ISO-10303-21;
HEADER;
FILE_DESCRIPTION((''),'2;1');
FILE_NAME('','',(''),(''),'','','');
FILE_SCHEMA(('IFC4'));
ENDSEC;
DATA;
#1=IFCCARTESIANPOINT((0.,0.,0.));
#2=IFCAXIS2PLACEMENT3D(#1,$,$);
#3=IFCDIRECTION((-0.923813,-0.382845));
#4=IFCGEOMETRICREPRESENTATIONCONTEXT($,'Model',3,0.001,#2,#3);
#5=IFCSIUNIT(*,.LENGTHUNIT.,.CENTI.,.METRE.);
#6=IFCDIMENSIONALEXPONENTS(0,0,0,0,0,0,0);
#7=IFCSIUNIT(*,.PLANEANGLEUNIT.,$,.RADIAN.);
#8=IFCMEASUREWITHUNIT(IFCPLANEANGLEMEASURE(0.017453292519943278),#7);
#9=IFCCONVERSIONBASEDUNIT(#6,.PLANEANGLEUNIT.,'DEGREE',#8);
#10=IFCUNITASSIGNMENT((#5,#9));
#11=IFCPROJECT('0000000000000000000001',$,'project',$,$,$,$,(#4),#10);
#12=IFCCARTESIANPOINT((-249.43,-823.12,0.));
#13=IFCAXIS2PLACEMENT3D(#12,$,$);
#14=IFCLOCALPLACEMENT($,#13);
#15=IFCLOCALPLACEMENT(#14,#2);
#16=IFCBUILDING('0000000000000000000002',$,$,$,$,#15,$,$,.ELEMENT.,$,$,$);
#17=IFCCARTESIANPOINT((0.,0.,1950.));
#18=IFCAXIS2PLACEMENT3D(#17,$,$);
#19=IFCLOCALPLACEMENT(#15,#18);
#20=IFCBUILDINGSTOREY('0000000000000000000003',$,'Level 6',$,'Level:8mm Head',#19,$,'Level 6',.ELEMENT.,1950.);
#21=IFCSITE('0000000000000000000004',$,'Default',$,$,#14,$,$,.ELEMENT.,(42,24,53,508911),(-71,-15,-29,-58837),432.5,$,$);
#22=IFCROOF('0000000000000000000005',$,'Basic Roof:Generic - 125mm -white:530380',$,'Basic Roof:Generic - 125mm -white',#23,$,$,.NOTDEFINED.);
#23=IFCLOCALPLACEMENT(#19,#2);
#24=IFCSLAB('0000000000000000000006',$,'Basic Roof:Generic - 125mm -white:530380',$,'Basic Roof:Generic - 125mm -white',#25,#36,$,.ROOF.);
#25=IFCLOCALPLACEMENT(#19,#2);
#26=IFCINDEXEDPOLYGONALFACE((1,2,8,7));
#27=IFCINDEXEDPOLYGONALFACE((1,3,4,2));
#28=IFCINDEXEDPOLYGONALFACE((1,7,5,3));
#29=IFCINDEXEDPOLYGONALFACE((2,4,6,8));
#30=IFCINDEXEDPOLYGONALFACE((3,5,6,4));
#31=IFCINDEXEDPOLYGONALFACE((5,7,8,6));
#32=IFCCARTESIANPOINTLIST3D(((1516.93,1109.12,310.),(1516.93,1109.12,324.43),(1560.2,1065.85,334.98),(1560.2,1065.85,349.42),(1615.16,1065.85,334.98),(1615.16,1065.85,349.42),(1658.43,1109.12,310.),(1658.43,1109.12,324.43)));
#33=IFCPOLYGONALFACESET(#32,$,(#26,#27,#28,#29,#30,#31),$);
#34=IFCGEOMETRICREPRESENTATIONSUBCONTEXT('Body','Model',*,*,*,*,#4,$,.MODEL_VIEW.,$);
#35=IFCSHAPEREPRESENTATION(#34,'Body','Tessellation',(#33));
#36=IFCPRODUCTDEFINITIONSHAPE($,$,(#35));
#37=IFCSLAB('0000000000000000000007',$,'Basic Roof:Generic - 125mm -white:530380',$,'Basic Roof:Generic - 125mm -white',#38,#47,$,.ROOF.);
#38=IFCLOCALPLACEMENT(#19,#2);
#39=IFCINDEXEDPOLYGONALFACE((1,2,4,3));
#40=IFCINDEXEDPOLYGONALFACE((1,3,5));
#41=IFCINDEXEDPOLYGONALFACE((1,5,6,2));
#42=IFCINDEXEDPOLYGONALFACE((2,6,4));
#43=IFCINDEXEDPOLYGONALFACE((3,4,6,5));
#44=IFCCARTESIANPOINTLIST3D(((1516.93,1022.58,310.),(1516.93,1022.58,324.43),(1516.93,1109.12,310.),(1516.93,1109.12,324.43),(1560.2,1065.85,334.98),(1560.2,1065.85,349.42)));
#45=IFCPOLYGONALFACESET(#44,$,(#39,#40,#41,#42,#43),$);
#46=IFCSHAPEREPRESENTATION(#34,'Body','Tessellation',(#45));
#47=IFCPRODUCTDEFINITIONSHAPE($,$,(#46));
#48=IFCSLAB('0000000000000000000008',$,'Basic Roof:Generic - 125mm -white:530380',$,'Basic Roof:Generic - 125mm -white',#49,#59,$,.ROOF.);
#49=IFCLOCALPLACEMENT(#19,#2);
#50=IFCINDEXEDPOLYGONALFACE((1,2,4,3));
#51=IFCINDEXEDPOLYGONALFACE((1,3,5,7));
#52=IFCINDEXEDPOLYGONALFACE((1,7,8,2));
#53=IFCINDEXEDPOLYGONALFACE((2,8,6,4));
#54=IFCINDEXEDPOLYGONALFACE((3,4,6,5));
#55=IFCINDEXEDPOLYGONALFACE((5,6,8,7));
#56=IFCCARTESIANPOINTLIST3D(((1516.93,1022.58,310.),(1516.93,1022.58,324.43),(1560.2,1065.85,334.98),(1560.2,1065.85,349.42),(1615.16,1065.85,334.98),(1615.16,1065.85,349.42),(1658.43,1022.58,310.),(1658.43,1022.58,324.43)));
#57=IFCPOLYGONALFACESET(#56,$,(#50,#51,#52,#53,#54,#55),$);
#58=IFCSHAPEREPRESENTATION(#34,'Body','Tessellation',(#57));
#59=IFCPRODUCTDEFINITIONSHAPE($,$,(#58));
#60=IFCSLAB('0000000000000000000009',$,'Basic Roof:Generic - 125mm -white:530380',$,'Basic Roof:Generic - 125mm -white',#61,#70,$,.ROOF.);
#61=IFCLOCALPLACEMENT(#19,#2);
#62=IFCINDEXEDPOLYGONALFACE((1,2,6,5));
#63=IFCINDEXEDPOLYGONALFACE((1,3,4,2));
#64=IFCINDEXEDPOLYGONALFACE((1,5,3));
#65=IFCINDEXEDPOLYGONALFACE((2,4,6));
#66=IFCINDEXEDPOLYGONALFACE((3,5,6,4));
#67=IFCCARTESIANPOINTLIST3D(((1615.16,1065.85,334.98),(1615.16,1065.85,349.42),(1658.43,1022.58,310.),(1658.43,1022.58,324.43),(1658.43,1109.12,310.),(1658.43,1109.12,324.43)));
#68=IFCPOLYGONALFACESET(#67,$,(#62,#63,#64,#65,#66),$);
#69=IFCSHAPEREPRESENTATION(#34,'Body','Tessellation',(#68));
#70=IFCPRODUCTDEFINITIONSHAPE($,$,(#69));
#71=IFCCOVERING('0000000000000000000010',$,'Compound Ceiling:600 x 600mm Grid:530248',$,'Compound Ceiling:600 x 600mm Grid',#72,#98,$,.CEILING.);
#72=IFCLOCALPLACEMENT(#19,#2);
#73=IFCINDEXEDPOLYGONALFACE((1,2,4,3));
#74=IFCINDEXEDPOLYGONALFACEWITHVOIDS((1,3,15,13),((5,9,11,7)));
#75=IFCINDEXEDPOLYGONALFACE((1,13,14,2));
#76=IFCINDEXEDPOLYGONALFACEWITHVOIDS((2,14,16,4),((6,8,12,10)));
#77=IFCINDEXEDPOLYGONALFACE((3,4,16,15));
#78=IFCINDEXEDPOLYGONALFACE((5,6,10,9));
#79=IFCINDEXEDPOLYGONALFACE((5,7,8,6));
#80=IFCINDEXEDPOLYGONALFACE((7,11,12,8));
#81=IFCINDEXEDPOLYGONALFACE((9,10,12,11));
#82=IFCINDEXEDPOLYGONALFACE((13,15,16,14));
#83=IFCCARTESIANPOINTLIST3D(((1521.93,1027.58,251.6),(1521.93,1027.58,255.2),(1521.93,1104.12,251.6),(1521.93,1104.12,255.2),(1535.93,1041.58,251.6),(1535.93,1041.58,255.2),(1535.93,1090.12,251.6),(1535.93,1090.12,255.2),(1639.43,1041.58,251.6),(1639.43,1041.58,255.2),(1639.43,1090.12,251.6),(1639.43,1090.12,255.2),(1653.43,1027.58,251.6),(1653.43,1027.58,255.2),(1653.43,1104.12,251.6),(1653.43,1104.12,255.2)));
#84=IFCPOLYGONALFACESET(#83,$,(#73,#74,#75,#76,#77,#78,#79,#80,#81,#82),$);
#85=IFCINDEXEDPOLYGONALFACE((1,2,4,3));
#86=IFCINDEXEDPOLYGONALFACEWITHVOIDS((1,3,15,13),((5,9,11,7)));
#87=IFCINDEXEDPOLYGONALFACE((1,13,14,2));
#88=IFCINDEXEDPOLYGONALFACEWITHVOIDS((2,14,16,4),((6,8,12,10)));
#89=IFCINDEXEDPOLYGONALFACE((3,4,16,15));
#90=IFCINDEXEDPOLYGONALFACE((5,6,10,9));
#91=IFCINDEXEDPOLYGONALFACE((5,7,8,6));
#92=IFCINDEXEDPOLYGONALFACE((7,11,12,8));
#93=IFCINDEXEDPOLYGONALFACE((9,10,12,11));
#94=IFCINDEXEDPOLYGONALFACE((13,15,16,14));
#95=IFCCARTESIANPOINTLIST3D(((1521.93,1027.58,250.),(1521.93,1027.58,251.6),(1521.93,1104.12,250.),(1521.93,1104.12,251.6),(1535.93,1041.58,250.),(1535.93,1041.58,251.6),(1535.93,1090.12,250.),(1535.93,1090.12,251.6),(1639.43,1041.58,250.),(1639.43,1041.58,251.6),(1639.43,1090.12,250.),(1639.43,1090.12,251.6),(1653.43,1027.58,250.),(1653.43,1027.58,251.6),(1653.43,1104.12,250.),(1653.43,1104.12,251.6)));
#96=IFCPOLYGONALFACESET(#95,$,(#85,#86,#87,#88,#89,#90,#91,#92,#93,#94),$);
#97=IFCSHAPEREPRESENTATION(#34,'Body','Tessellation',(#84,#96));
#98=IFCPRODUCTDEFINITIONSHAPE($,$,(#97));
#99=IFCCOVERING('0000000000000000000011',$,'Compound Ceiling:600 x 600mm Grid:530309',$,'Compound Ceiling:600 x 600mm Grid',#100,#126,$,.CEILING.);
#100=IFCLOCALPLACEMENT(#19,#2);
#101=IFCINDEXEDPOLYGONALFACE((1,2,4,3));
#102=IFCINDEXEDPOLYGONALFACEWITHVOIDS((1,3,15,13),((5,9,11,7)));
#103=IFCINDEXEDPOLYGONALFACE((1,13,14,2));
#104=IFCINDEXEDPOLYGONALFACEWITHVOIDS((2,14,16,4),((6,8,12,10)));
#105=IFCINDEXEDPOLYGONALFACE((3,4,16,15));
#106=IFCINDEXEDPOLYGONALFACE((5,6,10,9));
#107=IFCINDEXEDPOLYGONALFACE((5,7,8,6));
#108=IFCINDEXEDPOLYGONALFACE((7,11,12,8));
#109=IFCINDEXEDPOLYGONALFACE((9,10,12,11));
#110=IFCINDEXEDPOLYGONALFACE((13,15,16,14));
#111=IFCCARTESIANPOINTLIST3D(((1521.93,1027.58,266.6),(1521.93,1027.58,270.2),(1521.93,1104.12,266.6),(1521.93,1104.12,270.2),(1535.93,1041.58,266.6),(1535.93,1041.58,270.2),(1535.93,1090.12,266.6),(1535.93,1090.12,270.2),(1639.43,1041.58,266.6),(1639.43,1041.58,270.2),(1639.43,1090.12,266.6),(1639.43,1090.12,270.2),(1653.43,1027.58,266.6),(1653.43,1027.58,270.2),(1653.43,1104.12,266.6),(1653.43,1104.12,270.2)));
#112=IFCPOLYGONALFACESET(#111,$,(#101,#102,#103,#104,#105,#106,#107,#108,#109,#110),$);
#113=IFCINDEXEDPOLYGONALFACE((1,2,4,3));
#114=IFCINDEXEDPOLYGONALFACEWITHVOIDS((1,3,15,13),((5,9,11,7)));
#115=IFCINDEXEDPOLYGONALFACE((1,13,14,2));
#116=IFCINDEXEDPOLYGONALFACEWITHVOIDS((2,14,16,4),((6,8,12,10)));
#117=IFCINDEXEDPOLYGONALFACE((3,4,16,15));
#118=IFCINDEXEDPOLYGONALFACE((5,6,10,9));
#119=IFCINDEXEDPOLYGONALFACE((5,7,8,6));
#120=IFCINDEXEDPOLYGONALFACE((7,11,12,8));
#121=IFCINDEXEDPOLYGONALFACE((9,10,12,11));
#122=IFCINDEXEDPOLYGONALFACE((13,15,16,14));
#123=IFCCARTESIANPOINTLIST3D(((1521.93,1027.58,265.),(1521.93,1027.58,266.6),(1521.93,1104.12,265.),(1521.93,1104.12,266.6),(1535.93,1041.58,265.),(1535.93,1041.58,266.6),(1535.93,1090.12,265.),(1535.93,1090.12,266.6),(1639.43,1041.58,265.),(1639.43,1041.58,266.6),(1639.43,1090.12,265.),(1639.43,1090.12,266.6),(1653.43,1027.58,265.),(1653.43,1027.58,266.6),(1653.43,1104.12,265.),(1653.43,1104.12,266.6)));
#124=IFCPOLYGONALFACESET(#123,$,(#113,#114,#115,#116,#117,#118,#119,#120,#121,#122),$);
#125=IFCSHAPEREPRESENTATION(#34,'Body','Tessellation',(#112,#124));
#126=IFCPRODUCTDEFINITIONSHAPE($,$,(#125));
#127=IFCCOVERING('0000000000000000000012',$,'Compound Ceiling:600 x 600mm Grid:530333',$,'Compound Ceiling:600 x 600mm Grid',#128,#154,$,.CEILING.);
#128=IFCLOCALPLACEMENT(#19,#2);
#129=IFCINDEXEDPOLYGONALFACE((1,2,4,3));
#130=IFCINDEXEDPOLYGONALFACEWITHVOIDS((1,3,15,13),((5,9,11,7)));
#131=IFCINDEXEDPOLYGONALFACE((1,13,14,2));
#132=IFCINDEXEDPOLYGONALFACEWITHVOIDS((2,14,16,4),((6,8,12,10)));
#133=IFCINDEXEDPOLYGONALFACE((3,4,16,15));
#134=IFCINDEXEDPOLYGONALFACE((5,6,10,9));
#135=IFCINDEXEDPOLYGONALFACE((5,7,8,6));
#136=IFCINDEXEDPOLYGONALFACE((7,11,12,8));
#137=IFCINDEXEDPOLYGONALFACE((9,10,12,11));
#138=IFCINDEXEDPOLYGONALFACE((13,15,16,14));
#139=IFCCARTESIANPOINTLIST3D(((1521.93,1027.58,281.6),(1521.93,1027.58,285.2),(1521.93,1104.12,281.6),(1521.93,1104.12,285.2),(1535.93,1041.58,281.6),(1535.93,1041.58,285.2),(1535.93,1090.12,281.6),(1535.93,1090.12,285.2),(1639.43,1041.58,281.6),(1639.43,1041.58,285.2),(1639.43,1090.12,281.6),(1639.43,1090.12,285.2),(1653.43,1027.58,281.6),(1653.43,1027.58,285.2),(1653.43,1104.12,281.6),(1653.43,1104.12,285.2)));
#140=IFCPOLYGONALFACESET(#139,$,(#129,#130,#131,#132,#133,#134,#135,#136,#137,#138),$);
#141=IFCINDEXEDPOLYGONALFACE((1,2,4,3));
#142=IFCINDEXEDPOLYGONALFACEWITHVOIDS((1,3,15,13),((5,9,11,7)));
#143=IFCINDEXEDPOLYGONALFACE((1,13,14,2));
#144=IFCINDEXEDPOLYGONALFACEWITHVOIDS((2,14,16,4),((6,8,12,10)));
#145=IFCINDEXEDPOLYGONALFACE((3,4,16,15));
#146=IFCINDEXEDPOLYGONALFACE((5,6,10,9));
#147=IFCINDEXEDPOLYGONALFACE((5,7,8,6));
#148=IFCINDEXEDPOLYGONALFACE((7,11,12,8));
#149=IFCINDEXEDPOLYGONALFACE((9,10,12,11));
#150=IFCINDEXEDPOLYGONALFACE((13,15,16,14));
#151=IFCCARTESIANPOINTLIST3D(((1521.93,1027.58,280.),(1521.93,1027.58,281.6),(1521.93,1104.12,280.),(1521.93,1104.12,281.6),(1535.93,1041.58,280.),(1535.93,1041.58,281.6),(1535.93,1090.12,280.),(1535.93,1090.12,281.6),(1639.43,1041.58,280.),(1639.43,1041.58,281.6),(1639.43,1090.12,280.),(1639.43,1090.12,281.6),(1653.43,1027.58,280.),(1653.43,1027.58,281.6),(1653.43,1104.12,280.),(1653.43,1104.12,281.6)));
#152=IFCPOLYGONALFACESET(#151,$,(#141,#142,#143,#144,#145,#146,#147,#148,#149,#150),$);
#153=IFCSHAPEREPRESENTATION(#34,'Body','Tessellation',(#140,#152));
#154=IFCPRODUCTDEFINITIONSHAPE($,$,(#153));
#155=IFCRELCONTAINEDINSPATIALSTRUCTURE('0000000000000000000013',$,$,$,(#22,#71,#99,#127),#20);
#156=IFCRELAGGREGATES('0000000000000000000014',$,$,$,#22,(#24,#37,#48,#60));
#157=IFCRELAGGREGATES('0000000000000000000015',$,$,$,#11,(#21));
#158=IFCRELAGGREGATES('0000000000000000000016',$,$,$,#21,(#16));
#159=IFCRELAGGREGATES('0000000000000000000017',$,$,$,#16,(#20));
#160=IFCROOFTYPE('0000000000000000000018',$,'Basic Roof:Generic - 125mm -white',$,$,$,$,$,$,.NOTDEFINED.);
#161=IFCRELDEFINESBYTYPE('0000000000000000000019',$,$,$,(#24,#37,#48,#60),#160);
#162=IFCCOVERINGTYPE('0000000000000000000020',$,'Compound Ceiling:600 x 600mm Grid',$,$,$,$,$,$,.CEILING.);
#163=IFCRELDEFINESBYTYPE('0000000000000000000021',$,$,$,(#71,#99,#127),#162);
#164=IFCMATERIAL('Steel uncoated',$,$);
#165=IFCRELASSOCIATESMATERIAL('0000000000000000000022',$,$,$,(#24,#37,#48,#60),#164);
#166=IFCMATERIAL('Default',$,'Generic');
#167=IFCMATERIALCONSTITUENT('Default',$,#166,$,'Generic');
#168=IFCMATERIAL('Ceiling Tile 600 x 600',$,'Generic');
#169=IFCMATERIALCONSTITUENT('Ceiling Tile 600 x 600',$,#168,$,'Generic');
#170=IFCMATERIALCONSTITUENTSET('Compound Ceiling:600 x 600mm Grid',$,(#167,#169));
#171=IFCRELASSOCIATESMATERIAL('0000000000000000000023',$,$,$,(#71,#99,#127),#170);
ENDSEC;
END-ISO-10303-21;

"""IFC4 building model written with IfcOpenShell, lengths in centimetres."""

from ifc_helpers import new_model, entity, si_unit, converted_unit, direction, frame, origin, place, context, subcontext, project, spatial, indexed_curve, outline, extrude, material, constituent, constituent_set, type_object, element, aggregate, save


model = new_model("IFC4")

# Units and contexts
model_context = context("Model", 3, precision=0.001, world=origin(), true_north=direction((-0.923813, -0.382845)))
body_context = subcontext(model_context, "Body", "Model", "MODEL_VIEW")
ifc_project = project(units=[si_unit("LENGTHUNIT", "METRE", prefix="CENTI"), converted_unit("PLANEANGLEUNIT", "DEGREE", entity("IfcPlaneAngleMeasure", 0.017453292519943278), si_unit("PLANEANGLEUNIT", "RADIAN"), dimensions=[0, 0, 0, 0, 0, 0, 0])], contexts=[model_context])

# Site, building, storey
site_placement = place(None, frame((-249.43, -823.12, 0.0)))
site = spatial("IfcSite", under=ifc_project, at=site_placement, Name="Default", CompositionType="ELEMENT", RefLatitude=(42, 24, 53, 508911), RefLongitude=(-71, -15, -29, -58837), RefElevation=432.5)
building_placement = place(site_placement, origin())
building = spatial("IfcBuilding", under=site, at=building_placement, CompositionType="ELEMENT")
storey_placement = place(building_placement, frame((0.0, 0.0, 1950.0)))
storey = spatial("IfcBuildingStorey", under=building, at=storey_placement, Name="Level 6", ObjectType="Level:8mm Head", LongName="Level 6", CompositionType="ELEMENT", Elevation=1950.0)

# Roof, slabs
roof_placement = place(storey_placement, frame((1516.93, 1022.58, 310.0)))
roof = element("IfcRoof", 1, at=roof_placement, inside=storey, Name="Basic Roof:Generic - 125mm -white:530380", ObjectType="Basic Roof:Generic - 125mm -white", PredefinedType="NOTDEFINED")
ifc_material_1 = material(Name="Steel uncoated")
roof_type = type_object("IfcRoofType", Name="Basic Roof:Generic - 125mm -white", PredefinedType="NOTDEFINED")
slab_1_placement = place(roof_placement, origin())
slab_1 = element("IfcSlab", 2, at=slab_1_placement, type_object=roof_type, material=ifc_material_1, Name="Basic Roof:Generic - 125mm -white:530380", ObjectType="Basic Roof:Generic - 125mm -white", PredefinedType="ROOF", context=body_context, shape_type="SweptSolid", body=[
    extrude(outline(indexed_curve([(70.75, 24.98), (-70.75, 24.98), (-27.48, -24.98), (27.48, -24.98), (70.75, 24.98)], self_intersect=False)), frame((70.75, 64.9, 12.49), z_axis=(0.0, 0.5, 0.866025), x_axis=(1.0, 0.0, 0.0)), (0.0, -0.5, 0.866025), 14.43),
])
slab_2_placement = place(roof_placement, origin())
slab_2 = element("IfcSlab", 3, at=slab_2_placement, type_object=roof_type, material=ifc_material_1, Name="Basic Roof:Generic - 125mm -white:530380", ObjectType="Basic Roof:Generic - 125mm -white", PredefinedType="ROOF", context=body_context, shape_type="SweptSolid", body=[
    extrude(outline(indexed_curve([(-24.98, 43.27), (-24.98, -43.27), (24.98, 0.0), (-24.98, 43.27)], self_intersect=False)), frame((21.64, 43.27, 12.49), z_axis=(-0.5, 0.0, 0.866025), x_axis=(0.866025, 0.0, 0.5)), (0.5, 0.0, 0.866025), 14.43),
])
slab_3_placement = place(roof_placement, origin())
slab_3 = element("IfcSlab", 4, at=slab_3_placement, type_object=roof_type, material=ifc_material_1, Name="Basic Roof:Generic - 125mm -white:530380", ObjectType="Basic Roof:Generic - 125mm -white", PredefinedType="ROOF", context=body_context, shape_type="SweptSolid", body=[
    extrude(outline(indexed_curve([(-70.75, -24.98), (70.75, -24.98), (27.48, 24.98), (-27.48, 24.98), (-70.75, -24.98)], self_intersect=False)), frame((70.75, 21.64, 12.49), z_axis=(0.0, -0.5, 0.866025), x_axis=(1.0, 0.0, 0.0)), (0.0, 0.5, 0.866025), 14.43),
])
slab_4_placement = place(roof_placement, origin())
slab_4 = element("IfcSlab", 5, at=slab_4_placement, type_object=roof_type, material=ifc_material_1, Name="Basic Roof:Generic - 125mm -white:530380", ObjectType="Basic Roof:Generic - 125mm -white", PredefinedType="ROOF", context=body_context, shape_type="SweptSolid", body=[
    extrude(outline(indexed_curve([(-24.98, 0.0), (24.98, -43.27), (24.98, 43.27), (-24.98, 0.0)], self_intersect=False)), frame((119.87, 43.27, 12.49), z_axis=(0.5, 0.0, 0.866025), x_axis=(0.866025, 0.0, -0.5)), (-0.5, 0.0, 0.866025), 14.43),
])
aggregate(roof, [slab_1, slab_2, slab_3, slab_4])

# Coverings
ifc_material_2 = material(Name="Default", Category="Generic")
ifc_constituent_1 = constituent(ifc_material_2, Name="Default", Category="Generic")
ifc_material_3 = material(Name="Ceiling Tile 600 x 600", Category="Generic")
ifc_constituent_2 = constituent(ifc_material_3, Name="Ceiling Tile 600 x 600", Category="Generic")
ifc_constituent_set_1 = constituent_set(constituents=[ifc_constituent_1, ifc_constituent_2], Name="Compound Ceiling:600 x 600mm Grid")
covering_type = type_object("IfcCoveringType", Name="Compound Ceiling:600 x 600mm Grid", PredefinedType="CEILING")
covering_1_placement = place(storey_placement, origin())
element("IfcCovering", 6, at=covering_1_placement, inside=storey, type_object=covering_type, material=ifc_constituent_set_1, Name="Compound Ceiling:600 x 600mm Grid:530248", ObjectType="Compound Ceiling:600 x 600mm Grid", PredefinedType="CEILING", context=body_context, shape_type="SweptSolid", body=[
    extrude(outline(indexed_curve([(-38.27, -65.75), (38.27, -65.75), (38.27, 65.75), (-38.27, 65.75), (-38.27, -65.75)], self_intersect=False), holes=[indexed_curve([(24.27, -51.75), (-24.27, -51.75), (-24.27, 51.75), (24.27, 51.75), (24.27, -51.75)], self_intersect=False)]), frame((1587.68, 1065.85, 251.6), z_axis=(0.0, 0.0, 1.0), x_axis=(0.0, -1.0, 0.0)), (0.0, 0.0, 1.0), 3.6),
    extrude(outline(indexed_curve([(-65.75, -38.27), (65.75, -38.27), (65.75, 38.27), (-65.75, 38.27), (-65.75, -38.27)], self_intersect=False), holes=[indexed_curve([(-51.75, 24.27), (51.75, 24.27), (51.75, -24.27), (-51.75, -24.27), (-51.75, 24.27)], self_intersect=False)]), frame((1587.68, 1065.85, 250.0), z_axis=(0.0, 0.0, 1.0), x_axis=(-1.0, 0.0, 0.0)), (0.0, 0.0, 1.0), 1.6),
])
covering_2_placement = place(storey_placement, origin())
element("IfcCovering", 7, at=covering_2_placement, inside=storey, type_object=covering_type, material=ifc_constituent_set_1, Name="Compound Ceiling:600 x 600mm Grid:530309", ObjectType="Compound Ceiling:600 x 600mm Grid", PredefinedType="CEILING", context=body_context, shape_type="SweptSolid", body=[
    extrude(outline(indexed_curve([(-38.27, -65.75), (38.27, -65.75), (38.27, 65.75), (-38.27, 65.75), (-38.27, -65.75)], self_intersect=False), holes=[indexed_curve([(24.27, -51.75), (-24.27, -51.75), (-24.27, 51.75), (24.27, 51.75), (24.27, -51.75)], self_intersect=False)]), frame((1587.68, 1065.85, 266.6), z_axis=(0.0, 0.0, 1.0), x_axis=(0.0, -1.0, 0.0)), (0.0, 0.0, 1.0), 3.6),
    extrude(outline(indexed_curve([(-65.75, -38.27), (65.75, -38.27), (65.75, 38.27), (-65.75, 38.27), (-65.75, -38.27)], self_intersect=False), holes=[indexed_curve([(-51.75, 24.27), (51.75, 24.27), (51.75, -24.27), (-51.75, -24.27), (-51.75, 24.27)], self_intersect=False)]), frame((1587.68, 1065.85, 265.0), z_axis=(0.0, 0.0, 1.0), x_axis=(-1.0, 0.0, 0.0)), (0.0, 0.0, 1.0), 1.6),
])
covering_3_placement = place(storey_placement, origin())
element("IfcCovering", 8, at=covering_3_placement, inside=storey, type_object=covering_type, material=ifc_constituent_set_1, Name="Compound Ceiling:600 x 600mm Grid:530333", ObjectType="Compound Ceiling:600 x 600mm Grid", PredefinedType="CEILING", context=body_context, shape_type="SweptSolid", body=[
    extrude(outline(indexed_curve([(-38.27, -65.75), (38.27, -65.75), (38.27, 65.75), (-38.27, 65.75), (-38.27, -65.75)], self_intersect=False), holes=[indexed_curve([(24.27, -51.75), (-24.27, -51.75), (-24.27, 51.75), (24.27, 51.75), (24.27, -51.75)], self_intersect=False)]), frame((1587.68, 1065.85, 281.6), z_axis=(0.0, 0.0, 1.0), x_axis=(0.0, -1.0, 0.0)), (0.0, 0.0, 1.0), 3.6),
    extrude(outline(indexed_curve([(-65.75, -38.27), (65.75, -38.27), (65.75, 38.27), (-65.75, 38.27), (-65.75, -38.27)], self_intersect=False), holes=[indexed_curve([(-51.75, 24.27), (51.75, 24.27), (51.75, -24.27), (-51.75, -24.27), (-51.75, 24.27)], self_intersect=False)]), frame((1587.68, 1065.85, 280.0), z_axis=(0.0, 0.0, 1.0), x_axis=(-1.0, 0.0, 0.0)), (0.0, 0.0, 1.0), 1.6),
])

save(model, "model.ifc")
